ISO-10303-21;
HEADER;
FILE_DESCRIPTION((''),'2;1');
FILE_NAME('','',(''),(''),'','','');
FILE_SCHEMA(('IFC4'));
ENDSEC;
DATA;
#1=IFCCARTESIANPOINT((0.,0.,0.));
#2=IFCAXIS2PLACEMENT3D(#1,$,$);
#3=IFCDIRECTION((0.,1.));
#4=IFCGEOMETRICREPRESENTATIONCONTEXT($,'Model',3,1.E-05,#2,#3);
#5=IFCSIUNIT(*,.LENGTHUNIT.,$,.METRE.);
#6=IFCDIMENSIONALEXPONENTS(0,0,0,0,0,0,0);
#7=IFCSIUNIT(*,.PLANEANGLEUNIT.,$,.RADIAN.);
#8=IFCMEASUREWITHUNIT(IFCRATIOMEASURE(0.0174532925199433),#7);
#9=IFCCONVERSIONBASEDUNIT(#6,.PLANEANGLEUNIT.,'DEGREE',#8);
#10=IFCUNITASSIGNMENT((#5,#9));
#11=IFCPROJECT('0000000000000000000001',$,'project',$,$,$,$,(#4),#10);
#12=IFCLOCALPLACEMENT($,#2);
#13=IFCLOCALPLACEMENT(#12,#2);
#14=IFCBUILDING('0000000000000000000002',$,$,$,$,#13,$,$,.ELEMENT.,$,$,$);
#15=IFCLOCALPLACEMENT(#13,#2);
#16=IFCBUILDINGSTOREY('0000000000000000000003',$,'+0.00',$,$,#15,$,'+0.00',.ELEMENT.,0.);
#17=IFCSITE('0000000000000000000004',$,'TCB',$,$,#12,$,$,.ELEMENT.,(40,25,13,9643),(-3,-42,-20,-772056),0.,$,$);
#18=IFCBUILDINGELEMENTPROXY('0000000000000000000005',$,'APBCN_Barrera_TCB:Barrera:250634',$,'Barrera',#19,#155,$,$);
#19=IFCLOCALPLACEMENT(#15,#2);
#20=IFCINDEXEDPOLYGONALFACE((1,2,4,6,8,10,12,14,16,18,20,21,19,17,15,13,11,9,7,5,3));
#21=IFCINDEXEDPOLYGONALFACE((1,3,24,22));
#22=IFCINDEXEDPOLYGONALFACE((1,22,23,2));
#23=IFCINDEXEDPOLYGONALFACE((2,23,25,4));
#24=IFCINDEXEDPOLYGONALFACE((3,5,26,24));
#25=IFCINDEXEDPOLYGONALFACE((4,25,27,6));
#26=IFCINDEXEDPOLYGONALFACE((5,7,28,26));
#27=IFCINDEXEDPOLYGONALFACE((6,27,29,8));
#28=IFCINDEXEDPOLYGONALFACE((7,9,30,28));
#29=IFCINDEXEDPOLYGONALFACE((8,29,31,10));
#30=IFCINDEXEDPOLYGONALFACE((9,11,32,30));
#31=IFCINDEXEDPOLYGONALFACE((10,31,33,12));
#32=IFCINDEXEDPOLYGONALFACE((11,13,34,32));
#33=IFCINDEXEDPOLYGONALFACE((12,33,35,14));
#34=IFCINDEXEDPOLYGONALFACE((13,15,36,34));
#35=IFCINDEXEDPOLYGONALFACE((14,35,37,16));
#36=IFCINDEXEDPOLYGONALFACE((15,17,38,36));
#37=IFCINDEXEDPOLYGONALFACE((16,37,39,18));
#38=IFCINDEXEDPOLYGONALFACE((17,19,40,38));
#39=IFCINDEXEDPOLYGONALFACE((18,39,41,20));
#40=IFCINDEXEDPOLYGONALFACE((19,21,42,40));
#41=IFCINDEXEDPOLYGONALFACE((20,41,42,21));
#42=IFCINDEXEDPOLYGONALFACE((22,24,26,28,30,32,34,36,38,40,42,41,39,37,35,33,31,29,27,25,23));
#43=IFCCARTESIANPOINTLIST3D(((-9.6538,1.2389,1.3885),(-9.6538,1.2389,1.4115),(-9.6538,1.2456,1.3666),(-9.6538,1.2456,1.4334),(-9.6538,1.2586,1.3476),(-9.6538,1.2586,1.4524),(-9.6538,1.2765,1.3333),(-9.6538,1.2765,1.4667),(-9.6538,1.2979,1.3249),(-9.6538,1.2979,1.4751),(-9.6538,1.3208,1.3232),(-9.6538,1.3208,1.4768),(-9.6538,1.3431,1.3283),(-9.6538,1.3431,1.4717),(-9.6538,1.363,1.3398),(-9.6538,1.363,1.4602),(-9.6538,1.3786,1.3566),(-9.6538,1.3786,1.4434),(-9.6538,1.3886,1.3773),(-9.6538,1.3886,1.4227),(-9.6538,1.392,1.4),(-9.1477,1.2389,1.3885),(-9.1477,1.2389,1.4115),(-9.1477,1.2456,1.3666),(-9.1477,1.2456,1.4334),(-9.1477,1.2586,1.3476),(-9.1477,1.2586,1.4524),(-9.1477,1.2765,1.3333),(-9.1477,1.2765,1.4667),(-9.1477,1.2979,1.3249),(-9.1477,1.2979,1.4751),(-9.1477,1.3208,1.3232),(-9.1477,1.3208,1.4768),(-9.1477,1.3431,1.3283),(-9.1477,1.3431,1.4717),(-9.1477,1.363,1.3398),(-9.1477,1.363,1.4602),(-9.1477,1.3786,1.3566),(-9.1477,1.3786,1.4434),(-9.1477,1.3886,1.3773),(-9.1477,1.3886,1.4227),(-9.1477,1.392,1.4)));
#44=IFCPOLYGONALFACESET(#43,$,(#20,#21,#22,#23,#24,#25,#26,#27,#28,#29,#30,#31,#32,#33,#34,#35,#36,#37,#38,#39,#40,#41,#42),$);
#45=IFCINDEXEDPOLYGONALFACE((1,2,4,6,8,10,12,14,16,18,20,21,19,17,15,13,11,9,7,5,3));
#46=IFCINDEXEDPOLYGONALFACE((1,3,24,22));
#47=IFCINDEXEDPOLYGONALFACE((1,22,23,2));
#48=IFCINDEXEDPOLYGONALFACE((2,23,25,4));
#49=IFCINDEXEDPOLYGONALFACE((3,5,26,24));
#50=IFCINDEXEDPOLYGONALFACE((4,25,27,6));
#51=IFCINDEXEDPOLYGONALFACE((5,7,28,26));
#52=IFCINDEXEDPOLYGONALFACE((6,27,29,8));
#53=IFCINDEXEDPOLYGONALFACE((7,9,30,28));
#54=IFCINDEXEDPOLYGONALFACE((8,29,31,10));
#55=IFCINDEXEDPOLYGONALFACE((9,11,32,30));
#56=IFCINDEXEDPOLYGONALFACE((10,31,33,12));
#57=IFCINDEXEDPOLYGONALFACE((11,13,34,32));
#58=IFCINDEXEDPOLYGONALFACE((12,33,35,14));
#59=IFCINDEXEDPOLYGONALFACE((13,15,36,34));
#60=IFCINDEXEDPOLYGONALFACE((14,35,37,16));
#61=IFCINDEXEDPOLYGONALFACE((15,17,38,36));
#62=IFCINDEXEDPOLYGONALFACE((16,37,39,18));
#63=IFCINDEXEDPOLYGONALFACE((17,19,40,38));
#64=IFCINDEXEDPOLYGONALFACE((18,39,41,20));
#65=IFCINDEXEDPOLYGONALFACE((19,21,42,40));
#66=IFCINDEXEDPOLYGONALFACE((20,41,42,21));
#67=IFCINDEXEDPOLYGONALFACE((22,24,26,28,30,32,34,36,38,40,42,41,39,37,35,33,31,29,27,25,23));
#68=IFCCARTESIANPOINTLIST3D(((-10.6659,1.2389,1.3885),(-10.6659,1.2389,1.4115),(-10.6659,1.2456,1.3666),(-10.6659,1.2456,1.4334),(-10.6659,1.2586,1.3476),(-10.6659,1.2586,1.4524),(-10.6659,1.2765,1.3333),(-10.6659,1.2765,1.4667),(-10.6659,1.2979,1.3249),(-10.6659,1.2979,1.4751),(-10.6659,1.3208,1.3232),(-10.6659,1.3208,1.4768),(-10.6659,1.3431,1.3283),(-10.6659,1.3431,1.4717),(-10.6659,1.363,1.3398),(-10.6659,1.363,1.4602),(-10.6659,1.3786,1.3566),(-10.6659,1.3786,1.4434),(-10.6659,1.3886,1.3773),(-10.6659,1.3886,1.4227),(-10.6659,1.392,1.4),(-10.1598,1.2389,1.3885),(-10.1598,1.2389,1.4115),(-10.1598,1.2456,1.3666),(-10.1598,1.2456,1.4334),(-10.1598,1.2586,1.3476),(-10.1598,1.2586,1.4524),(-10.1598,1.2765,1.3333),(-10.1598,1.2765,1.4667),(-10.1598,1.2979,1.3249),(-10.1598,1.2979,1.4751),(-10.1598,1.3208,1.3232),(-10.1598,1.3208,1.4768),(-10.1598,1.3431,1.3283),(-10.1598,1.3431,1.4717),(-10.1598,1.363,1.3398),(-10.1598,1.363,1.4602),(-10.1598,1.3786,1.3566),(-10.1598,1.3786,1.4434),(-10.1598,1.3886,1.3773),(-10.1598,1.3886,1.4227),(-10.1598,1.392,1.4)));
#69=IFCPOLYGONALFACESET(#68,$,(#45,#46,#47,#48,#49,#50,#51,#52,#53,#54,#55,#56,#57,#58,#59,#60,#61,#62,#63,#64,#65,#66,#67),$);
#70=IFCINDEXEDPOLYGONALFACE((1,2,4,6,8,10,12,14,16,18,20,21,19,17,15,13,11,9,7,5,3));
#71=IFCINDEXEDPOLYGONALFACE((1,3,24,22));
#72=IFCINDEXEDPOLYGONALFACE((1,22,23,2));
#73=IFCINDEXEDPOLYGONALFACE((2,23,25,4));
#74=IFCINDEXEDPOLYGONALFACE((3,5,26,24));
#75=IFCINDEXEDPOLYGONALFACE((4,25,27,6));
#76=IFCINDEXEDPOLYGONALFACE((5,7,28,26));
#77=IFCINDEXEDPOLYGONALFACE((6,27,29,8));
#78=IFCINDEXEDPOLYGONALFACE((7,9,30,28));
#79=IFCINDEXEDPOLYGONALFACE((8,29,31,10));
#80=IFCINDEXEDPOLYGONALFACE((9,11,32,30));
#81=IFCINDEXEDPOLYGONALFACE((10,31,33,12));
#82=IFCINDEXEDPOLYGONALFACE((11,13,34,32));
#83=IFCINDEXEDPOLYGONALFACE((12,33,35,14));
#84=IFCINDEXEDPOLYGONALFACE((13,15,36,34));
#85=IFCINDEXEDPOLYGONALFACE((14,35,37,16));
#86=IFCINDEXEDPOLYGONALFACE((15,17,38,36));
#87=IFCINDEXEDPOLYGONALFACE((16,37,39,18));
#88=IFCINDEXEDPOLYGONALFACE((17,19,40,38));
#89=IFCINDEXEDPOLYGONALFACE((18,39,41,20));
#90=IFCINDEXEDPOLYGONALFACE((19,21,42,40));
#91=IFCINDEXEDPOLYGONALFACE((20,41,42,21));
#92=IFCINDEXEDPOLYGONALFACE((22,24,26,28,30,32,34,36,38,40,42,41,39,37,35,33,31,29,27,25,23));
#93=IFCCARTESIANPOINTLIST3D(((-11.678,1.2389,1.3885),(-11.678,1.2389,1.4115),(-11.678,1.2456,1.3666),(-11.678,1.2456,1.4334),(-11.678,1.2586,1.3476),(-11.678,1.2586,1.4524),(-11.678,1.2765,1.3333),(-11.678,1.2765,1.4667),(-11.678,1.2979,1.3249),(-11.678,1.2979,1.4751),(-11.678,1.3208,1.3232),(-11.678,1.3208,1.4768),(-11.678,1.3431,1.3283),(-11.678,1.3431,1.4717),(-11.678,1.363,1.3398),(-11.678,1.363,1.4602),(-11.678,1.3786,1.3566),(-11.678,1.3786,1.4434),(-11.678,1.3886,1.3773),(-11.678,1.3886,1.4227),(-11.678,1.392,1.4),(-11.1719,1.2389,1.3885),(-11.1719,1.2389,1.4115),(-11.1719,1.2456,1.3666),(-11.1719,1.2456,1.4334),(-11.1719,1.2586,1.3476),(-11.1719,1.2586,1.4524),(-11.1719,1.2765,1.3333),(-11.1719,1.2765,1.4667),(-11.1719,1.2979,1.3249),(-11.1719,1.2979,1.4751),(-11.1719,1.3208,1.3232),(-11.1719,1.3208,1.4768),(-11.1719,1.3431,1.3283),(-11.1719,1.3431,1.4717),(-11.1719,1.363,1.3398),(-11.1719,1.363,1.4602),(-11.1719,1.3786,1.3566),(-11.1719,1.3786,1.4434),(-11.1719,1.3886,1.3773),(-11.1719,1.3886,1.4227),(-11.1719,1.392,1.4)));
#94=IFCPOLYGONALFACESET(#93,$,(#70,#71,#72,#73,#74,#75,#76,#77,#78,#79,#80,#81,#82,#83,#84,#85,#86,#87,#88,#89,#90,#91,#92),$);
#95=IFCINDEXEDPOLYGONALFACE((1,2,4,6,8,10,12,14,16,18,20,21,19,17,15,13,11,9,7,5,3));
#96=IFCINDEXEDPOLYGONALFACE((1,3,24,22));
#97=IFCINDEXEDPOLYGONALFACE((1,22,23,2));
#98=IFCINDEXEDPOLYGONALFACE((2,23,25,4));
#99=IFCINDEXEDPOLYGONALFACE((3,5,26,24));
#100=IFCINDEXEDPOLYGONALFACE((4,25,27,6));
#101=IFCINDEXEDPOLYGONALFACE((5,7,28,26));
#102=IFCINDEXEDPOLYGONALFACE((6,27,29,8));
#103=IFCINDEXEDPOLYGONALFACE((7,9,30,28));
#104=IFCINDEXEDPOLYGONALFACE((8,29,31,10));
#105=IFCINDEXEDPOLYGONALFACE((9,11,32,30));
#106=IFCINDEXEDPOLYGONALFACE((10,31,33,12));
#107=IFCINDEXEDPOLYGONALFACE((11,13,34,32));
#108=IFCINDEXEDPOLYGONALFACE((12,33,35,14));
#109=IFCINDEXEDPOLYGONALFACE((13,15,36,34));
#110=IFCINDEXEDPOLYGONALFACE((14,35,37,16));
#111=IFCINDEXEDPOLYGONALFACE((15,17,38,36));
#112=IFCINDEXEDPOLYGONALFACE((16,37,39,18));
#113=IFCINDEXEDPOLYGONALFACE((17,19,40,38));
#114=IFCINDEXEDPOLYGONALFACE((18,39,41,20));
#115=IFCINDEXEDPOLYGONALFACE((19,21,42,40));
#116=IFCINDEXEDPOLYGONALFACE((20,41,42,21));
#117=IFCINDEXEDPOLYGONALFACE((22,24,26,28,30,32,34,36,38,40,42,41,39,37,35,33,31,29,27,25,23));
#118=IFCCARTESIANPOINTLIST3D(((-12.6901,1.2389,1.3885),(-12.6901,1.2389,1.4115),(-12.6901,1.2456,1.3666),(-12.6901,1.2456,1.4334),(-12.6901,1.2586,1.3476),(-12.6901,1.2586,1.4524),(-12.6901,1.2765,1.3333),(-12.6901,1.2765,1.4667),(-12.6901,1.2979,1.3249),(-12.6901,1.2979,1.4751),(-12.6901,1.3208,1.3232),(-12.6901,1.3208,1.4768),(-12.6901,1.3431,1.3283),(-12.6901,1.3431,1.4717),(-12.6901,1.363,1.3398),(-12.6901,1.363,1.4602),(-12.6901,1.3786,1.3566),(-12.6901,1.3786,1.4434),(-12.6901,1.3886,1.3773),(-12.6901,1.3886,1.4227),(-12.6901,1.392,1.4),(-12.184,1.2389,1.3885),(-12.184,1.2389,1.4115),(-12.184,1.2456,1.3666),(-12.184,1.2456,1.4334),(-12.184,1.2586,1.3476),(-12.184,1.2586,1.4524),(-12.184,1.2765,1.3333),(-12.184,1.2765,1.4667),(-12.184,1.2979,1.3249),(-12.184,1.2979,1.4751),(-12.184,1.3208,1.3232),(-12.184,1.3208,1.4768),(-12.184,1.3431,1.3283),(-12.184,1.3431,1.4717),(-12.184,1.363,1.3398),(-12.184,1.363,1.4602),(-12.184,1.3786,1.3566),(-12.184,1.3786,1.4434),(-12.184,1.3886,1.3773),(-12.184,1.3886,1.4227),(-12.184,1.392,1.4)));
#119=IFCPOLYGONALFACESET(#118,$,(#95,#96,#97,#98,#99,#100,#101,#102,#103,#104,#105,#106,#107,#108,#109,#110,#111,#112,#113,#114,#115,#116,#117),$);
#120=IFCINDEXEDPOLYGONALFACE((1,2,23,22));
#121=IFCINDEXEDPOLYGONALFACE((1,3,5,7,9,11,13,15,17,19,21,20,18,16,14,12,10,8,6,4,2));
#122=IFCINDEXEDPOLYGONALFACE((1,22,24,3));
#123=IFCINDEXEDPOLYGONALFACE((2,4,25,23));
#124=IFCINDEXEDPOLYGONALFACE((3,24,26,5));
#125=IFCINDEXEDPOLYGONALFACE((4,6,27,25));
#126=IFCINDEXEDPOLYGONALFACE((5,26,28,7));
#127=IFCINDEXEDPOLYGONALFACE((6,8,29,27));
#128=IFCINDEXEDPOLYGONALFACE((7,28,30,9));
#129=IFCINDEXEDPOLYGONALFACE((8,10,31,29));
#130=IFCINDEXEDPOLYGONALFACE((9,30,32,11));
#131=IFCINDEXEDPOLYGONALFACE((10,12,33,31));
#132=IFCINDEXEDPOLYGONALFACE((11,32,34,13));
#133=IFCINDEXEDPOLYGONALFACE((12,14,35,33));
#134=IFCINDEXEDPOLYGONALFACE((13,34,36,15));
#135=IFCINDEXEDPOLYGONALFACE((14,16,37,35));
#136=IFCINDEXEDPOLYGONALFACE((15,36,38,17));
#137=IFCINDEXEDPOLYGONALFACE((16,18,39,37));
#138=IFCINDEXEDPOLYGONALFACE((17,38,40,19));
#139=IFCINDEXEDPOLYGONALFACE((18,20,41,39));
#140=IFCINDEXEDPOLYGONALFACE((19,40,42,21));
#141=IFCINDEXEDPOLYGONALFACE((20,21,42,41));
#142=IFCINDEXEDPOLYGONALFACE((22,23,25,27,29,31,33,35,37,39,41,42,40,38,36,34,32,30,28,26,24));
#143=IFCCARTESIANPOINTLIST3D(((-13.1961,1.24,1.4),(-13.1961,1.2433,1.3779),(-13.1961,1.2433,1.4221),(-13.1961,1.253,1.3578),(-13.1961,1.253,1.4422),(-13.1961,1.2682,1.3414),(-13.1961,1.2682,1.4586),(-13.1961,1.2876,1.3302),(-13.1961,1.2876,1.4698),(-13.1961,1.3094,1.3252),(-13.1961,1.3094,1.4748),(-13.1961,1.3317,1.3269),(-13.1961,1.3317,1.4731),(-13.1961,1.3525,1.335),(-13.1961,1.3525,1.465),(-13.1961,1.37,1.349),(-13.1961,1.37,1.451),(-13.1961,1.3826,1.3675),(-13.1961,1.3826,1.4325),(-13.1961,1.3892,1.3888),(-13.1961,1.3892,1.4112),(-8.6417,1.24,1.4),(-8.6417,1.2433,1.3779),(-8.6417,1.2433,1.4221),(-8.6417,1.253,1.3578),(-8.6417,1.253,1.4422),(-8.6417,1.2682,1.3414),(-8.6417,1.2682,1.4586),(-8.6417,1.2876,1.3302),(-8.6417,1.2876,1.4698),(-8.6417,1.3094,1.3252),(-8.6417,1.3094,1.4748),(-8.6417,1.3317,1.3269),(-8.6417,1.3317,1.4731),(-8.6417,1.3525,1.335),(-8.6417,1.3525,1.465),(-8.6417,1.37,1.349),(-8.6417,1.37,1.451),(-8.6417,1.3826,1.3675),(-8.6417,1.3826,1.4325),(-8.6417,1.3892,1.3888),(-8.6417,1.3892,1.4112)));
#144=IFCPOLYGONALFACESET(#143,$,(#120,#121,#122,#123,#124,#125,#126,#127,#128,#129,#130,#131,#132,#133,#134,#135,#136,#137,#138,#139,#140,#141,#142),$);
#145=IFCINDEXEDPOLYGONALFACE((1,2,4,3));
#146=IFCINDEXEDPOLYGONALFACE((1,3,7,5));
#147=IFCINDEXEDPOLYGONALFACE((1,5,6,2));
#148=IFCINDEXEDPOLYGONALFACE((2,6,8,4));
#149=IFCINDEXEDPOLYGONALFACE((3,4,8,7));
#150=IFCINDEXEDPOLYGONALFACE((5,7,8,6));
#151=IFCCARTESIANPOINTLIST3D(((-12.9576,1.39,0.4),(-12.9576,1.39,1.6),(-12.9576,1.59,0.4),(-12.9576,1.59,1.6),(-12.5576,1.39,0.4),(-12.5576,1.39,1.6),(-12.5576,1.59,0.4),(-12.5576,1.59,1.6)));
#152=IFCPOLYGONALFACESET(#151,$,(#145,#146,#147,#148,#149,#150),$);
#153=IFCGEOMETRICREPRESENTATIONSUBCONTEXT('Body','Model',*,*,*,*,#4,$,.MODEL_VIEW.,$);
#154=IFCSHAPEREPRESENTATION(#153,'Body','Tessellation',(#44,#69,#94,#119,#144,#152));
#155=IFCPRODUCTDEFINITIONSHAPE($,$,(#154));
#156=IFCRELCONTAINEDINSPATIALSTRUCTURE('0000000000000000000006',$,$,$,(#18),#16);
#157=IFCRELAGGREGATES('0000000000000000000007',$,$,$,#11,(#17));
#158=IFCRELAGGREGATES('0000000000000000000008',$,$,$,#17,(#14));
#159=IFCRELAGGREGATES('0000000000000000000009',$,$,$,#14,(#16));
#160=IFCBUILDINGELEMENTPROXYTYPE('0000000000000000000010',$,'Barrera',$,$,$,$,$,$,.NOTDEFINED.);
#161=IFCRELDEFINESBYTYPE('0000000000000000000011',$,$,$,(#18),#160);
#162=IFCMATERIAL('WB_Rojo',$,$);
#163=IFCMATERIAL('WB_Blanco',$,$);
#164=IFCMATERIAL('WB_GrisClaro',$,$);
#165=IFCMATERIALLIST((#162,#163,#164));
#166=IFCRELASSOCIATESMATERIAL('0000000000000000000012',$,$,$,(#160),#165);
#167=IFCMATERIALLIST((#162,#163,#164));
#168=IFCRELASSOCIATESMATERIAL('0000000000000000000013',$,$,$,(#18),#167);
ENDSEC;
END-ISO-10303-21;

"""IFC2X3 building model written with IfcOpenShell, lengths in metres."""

from ifc_helpers import new_model, entity, si_unit, converted_unit, direction, frame, frame_2d, origin, place, context, subcontext, project, spatial, rectangle, circle, extrude, source, transform, mapped, material, material_list, type_object, type_shapes, element, save


model = new_model("IFC2X3")

# Units and contexts
model_context = context("Model", 3, precision=1e-05, world=origin(), true_north=direction((0.0, 1.0)))
body_context = subcontext(model_context, "Body", "Model", "MODEL_VIEW")
ifc_project = project(units=[si_unit("LENGTHUNIT", "METRE"), converted_unit("PLANEANGLEUNIT", "DEGREE", entity("IfcRatioMeasure", 0.0174532925199433), si_unit("PLANEANGLEUNIT", "RADIAN"), dimensions=[0, 0, 0, 0, 0, 0, 0])], contexts=[model_context])

# Site, building, storey
site_placement = place(None, origin())
site = spatial("IfcSite", under=ifc_project, at=site_placement, Name="TCB", CompositionType="ELEMENT", RefLatitude=(40, 25, 13, 9643), RefLongitude=(-3, -42, -20, -772056), RefElevation=0.0)
building_placement = place(site_placement, origin())
building = spatial("IfcBuilding", under=site, at=building_placement, CompositionType="ELEMENT")
storey_placement = place(building_placement, origin())
storey = spatial("IfcBuildingStorey", under=building, at=storey_placement, Name="+0.00", LongName="+0.00", CompositionType="ELEMENT", Elevation=0.0)

# Shared definitions
ifc_material_1 = material(Name="WB_Blanco")

# Building element proxy
ifc_material_2 = material(Name="WB_Rojo")
ifc_material_3 = material(Name="WB_GrisClaro")
ifc_material_list_1 = material_list([ifc_material_2, ifc_material_1, ifc_material_3])
building_element_proxy_type = type_object("IfcBuildingElementProxyType", Name="Barrera", PredefinedType="NOTDEFINED", material=ifc_material_list_1)
shared_shape_1 = source(origin(), body_context, "Body", "SweptSolid", [
    extrude(circle(Radius=0.077, at=frame_2d((0.0, 0.0), x_axis=(1.0, 0.0))), frame((2.8039, -0.175, 1.0), z_axis=(1.0, 0.0, 0.0), x_axis=(0.0, 1.0, 0.0)), (0.0, 0.0, 1.0), 0.506),
    extrude(circle(Radius=0.077, at=frame_2d((0.0, 0.0), x_axis=(1.0, 0.0))), frame((1.7918, -0.175, 1.0), z_axis=(1.0, 0.0, 0.0), x_axis=(0.0, 1.0, 0.0)), (0.0, 0.0, 1.0), 0.506),
    extrude(circle(Radius=0.077, at=frame_2d((0.0, 0.0), x_axis=(1.0, 0.0))), frame((0.7797, -0.175, 1.0), z_axis=(1.0, 0.0, 0.0), x_axis=(0.0, 1.0, 0.0)), (0.0, 0.0, 1.0), 0.506),
    extrude(circle(Radius=0.077, at=frame_2d((0.0, 0.0), x_axis=(1.0, 0.0))), frame((-0.2324, -0.175, 1.0), z_axis=(1.0, 0.0, 0.0), x_axis=(0.0, 1.0, 0.0)), (0.0, 0.0, 1.0), 0.506),
    extrude(circle(Radius=0.075, at=frame_2d((0.0, 0.0), x_axis=(1.0, 0.0))), frame((-0.7385, -0.175, 1.0), z_axis=(1.0, 0.0, 0.0), x_axis=(0.0, -1.0, 0.0)), (0.0, 0.0, 1.0), 4.5544),
    extrude(rectangle(XDim=0.2, YDim=0.4, at=frame_2d((0.0, 0.0), x_axis=(1.0, 0.0))), frame((-0.3, 0.0, 0.0), z_axis=(0.0, 0.0, 1.0), x_axis=(0.0, -1.0, 0.0)), (0.0, 0.0, 1.0), 1.2),
])
type_shapes(building_element_proxy_type, [shared_shape_1])
ifc_material_list_2 = material_list([ifc_material_2, ifc_material_1, ifc_material_3])
proxy_1_placement = place(storey_placement, frame((-12.4576, 1.49, 0.4)))
element("IfcBuildingElementProxy", 1, at=proxy_1_placement, inside=storey, type_object=building_element_proxy_type, material=ifc_material_list_2, Name="APBCN_Barrera_TCB:Barrera:250634", ObjectType="Barrera", context=body_context, shape_type="MappedRepresentation", body=[
    mapped(shared_shape_1, transform((0.0, 0.0, 0.0), scale=1.0)),
])

save(model, "model.ifc")
